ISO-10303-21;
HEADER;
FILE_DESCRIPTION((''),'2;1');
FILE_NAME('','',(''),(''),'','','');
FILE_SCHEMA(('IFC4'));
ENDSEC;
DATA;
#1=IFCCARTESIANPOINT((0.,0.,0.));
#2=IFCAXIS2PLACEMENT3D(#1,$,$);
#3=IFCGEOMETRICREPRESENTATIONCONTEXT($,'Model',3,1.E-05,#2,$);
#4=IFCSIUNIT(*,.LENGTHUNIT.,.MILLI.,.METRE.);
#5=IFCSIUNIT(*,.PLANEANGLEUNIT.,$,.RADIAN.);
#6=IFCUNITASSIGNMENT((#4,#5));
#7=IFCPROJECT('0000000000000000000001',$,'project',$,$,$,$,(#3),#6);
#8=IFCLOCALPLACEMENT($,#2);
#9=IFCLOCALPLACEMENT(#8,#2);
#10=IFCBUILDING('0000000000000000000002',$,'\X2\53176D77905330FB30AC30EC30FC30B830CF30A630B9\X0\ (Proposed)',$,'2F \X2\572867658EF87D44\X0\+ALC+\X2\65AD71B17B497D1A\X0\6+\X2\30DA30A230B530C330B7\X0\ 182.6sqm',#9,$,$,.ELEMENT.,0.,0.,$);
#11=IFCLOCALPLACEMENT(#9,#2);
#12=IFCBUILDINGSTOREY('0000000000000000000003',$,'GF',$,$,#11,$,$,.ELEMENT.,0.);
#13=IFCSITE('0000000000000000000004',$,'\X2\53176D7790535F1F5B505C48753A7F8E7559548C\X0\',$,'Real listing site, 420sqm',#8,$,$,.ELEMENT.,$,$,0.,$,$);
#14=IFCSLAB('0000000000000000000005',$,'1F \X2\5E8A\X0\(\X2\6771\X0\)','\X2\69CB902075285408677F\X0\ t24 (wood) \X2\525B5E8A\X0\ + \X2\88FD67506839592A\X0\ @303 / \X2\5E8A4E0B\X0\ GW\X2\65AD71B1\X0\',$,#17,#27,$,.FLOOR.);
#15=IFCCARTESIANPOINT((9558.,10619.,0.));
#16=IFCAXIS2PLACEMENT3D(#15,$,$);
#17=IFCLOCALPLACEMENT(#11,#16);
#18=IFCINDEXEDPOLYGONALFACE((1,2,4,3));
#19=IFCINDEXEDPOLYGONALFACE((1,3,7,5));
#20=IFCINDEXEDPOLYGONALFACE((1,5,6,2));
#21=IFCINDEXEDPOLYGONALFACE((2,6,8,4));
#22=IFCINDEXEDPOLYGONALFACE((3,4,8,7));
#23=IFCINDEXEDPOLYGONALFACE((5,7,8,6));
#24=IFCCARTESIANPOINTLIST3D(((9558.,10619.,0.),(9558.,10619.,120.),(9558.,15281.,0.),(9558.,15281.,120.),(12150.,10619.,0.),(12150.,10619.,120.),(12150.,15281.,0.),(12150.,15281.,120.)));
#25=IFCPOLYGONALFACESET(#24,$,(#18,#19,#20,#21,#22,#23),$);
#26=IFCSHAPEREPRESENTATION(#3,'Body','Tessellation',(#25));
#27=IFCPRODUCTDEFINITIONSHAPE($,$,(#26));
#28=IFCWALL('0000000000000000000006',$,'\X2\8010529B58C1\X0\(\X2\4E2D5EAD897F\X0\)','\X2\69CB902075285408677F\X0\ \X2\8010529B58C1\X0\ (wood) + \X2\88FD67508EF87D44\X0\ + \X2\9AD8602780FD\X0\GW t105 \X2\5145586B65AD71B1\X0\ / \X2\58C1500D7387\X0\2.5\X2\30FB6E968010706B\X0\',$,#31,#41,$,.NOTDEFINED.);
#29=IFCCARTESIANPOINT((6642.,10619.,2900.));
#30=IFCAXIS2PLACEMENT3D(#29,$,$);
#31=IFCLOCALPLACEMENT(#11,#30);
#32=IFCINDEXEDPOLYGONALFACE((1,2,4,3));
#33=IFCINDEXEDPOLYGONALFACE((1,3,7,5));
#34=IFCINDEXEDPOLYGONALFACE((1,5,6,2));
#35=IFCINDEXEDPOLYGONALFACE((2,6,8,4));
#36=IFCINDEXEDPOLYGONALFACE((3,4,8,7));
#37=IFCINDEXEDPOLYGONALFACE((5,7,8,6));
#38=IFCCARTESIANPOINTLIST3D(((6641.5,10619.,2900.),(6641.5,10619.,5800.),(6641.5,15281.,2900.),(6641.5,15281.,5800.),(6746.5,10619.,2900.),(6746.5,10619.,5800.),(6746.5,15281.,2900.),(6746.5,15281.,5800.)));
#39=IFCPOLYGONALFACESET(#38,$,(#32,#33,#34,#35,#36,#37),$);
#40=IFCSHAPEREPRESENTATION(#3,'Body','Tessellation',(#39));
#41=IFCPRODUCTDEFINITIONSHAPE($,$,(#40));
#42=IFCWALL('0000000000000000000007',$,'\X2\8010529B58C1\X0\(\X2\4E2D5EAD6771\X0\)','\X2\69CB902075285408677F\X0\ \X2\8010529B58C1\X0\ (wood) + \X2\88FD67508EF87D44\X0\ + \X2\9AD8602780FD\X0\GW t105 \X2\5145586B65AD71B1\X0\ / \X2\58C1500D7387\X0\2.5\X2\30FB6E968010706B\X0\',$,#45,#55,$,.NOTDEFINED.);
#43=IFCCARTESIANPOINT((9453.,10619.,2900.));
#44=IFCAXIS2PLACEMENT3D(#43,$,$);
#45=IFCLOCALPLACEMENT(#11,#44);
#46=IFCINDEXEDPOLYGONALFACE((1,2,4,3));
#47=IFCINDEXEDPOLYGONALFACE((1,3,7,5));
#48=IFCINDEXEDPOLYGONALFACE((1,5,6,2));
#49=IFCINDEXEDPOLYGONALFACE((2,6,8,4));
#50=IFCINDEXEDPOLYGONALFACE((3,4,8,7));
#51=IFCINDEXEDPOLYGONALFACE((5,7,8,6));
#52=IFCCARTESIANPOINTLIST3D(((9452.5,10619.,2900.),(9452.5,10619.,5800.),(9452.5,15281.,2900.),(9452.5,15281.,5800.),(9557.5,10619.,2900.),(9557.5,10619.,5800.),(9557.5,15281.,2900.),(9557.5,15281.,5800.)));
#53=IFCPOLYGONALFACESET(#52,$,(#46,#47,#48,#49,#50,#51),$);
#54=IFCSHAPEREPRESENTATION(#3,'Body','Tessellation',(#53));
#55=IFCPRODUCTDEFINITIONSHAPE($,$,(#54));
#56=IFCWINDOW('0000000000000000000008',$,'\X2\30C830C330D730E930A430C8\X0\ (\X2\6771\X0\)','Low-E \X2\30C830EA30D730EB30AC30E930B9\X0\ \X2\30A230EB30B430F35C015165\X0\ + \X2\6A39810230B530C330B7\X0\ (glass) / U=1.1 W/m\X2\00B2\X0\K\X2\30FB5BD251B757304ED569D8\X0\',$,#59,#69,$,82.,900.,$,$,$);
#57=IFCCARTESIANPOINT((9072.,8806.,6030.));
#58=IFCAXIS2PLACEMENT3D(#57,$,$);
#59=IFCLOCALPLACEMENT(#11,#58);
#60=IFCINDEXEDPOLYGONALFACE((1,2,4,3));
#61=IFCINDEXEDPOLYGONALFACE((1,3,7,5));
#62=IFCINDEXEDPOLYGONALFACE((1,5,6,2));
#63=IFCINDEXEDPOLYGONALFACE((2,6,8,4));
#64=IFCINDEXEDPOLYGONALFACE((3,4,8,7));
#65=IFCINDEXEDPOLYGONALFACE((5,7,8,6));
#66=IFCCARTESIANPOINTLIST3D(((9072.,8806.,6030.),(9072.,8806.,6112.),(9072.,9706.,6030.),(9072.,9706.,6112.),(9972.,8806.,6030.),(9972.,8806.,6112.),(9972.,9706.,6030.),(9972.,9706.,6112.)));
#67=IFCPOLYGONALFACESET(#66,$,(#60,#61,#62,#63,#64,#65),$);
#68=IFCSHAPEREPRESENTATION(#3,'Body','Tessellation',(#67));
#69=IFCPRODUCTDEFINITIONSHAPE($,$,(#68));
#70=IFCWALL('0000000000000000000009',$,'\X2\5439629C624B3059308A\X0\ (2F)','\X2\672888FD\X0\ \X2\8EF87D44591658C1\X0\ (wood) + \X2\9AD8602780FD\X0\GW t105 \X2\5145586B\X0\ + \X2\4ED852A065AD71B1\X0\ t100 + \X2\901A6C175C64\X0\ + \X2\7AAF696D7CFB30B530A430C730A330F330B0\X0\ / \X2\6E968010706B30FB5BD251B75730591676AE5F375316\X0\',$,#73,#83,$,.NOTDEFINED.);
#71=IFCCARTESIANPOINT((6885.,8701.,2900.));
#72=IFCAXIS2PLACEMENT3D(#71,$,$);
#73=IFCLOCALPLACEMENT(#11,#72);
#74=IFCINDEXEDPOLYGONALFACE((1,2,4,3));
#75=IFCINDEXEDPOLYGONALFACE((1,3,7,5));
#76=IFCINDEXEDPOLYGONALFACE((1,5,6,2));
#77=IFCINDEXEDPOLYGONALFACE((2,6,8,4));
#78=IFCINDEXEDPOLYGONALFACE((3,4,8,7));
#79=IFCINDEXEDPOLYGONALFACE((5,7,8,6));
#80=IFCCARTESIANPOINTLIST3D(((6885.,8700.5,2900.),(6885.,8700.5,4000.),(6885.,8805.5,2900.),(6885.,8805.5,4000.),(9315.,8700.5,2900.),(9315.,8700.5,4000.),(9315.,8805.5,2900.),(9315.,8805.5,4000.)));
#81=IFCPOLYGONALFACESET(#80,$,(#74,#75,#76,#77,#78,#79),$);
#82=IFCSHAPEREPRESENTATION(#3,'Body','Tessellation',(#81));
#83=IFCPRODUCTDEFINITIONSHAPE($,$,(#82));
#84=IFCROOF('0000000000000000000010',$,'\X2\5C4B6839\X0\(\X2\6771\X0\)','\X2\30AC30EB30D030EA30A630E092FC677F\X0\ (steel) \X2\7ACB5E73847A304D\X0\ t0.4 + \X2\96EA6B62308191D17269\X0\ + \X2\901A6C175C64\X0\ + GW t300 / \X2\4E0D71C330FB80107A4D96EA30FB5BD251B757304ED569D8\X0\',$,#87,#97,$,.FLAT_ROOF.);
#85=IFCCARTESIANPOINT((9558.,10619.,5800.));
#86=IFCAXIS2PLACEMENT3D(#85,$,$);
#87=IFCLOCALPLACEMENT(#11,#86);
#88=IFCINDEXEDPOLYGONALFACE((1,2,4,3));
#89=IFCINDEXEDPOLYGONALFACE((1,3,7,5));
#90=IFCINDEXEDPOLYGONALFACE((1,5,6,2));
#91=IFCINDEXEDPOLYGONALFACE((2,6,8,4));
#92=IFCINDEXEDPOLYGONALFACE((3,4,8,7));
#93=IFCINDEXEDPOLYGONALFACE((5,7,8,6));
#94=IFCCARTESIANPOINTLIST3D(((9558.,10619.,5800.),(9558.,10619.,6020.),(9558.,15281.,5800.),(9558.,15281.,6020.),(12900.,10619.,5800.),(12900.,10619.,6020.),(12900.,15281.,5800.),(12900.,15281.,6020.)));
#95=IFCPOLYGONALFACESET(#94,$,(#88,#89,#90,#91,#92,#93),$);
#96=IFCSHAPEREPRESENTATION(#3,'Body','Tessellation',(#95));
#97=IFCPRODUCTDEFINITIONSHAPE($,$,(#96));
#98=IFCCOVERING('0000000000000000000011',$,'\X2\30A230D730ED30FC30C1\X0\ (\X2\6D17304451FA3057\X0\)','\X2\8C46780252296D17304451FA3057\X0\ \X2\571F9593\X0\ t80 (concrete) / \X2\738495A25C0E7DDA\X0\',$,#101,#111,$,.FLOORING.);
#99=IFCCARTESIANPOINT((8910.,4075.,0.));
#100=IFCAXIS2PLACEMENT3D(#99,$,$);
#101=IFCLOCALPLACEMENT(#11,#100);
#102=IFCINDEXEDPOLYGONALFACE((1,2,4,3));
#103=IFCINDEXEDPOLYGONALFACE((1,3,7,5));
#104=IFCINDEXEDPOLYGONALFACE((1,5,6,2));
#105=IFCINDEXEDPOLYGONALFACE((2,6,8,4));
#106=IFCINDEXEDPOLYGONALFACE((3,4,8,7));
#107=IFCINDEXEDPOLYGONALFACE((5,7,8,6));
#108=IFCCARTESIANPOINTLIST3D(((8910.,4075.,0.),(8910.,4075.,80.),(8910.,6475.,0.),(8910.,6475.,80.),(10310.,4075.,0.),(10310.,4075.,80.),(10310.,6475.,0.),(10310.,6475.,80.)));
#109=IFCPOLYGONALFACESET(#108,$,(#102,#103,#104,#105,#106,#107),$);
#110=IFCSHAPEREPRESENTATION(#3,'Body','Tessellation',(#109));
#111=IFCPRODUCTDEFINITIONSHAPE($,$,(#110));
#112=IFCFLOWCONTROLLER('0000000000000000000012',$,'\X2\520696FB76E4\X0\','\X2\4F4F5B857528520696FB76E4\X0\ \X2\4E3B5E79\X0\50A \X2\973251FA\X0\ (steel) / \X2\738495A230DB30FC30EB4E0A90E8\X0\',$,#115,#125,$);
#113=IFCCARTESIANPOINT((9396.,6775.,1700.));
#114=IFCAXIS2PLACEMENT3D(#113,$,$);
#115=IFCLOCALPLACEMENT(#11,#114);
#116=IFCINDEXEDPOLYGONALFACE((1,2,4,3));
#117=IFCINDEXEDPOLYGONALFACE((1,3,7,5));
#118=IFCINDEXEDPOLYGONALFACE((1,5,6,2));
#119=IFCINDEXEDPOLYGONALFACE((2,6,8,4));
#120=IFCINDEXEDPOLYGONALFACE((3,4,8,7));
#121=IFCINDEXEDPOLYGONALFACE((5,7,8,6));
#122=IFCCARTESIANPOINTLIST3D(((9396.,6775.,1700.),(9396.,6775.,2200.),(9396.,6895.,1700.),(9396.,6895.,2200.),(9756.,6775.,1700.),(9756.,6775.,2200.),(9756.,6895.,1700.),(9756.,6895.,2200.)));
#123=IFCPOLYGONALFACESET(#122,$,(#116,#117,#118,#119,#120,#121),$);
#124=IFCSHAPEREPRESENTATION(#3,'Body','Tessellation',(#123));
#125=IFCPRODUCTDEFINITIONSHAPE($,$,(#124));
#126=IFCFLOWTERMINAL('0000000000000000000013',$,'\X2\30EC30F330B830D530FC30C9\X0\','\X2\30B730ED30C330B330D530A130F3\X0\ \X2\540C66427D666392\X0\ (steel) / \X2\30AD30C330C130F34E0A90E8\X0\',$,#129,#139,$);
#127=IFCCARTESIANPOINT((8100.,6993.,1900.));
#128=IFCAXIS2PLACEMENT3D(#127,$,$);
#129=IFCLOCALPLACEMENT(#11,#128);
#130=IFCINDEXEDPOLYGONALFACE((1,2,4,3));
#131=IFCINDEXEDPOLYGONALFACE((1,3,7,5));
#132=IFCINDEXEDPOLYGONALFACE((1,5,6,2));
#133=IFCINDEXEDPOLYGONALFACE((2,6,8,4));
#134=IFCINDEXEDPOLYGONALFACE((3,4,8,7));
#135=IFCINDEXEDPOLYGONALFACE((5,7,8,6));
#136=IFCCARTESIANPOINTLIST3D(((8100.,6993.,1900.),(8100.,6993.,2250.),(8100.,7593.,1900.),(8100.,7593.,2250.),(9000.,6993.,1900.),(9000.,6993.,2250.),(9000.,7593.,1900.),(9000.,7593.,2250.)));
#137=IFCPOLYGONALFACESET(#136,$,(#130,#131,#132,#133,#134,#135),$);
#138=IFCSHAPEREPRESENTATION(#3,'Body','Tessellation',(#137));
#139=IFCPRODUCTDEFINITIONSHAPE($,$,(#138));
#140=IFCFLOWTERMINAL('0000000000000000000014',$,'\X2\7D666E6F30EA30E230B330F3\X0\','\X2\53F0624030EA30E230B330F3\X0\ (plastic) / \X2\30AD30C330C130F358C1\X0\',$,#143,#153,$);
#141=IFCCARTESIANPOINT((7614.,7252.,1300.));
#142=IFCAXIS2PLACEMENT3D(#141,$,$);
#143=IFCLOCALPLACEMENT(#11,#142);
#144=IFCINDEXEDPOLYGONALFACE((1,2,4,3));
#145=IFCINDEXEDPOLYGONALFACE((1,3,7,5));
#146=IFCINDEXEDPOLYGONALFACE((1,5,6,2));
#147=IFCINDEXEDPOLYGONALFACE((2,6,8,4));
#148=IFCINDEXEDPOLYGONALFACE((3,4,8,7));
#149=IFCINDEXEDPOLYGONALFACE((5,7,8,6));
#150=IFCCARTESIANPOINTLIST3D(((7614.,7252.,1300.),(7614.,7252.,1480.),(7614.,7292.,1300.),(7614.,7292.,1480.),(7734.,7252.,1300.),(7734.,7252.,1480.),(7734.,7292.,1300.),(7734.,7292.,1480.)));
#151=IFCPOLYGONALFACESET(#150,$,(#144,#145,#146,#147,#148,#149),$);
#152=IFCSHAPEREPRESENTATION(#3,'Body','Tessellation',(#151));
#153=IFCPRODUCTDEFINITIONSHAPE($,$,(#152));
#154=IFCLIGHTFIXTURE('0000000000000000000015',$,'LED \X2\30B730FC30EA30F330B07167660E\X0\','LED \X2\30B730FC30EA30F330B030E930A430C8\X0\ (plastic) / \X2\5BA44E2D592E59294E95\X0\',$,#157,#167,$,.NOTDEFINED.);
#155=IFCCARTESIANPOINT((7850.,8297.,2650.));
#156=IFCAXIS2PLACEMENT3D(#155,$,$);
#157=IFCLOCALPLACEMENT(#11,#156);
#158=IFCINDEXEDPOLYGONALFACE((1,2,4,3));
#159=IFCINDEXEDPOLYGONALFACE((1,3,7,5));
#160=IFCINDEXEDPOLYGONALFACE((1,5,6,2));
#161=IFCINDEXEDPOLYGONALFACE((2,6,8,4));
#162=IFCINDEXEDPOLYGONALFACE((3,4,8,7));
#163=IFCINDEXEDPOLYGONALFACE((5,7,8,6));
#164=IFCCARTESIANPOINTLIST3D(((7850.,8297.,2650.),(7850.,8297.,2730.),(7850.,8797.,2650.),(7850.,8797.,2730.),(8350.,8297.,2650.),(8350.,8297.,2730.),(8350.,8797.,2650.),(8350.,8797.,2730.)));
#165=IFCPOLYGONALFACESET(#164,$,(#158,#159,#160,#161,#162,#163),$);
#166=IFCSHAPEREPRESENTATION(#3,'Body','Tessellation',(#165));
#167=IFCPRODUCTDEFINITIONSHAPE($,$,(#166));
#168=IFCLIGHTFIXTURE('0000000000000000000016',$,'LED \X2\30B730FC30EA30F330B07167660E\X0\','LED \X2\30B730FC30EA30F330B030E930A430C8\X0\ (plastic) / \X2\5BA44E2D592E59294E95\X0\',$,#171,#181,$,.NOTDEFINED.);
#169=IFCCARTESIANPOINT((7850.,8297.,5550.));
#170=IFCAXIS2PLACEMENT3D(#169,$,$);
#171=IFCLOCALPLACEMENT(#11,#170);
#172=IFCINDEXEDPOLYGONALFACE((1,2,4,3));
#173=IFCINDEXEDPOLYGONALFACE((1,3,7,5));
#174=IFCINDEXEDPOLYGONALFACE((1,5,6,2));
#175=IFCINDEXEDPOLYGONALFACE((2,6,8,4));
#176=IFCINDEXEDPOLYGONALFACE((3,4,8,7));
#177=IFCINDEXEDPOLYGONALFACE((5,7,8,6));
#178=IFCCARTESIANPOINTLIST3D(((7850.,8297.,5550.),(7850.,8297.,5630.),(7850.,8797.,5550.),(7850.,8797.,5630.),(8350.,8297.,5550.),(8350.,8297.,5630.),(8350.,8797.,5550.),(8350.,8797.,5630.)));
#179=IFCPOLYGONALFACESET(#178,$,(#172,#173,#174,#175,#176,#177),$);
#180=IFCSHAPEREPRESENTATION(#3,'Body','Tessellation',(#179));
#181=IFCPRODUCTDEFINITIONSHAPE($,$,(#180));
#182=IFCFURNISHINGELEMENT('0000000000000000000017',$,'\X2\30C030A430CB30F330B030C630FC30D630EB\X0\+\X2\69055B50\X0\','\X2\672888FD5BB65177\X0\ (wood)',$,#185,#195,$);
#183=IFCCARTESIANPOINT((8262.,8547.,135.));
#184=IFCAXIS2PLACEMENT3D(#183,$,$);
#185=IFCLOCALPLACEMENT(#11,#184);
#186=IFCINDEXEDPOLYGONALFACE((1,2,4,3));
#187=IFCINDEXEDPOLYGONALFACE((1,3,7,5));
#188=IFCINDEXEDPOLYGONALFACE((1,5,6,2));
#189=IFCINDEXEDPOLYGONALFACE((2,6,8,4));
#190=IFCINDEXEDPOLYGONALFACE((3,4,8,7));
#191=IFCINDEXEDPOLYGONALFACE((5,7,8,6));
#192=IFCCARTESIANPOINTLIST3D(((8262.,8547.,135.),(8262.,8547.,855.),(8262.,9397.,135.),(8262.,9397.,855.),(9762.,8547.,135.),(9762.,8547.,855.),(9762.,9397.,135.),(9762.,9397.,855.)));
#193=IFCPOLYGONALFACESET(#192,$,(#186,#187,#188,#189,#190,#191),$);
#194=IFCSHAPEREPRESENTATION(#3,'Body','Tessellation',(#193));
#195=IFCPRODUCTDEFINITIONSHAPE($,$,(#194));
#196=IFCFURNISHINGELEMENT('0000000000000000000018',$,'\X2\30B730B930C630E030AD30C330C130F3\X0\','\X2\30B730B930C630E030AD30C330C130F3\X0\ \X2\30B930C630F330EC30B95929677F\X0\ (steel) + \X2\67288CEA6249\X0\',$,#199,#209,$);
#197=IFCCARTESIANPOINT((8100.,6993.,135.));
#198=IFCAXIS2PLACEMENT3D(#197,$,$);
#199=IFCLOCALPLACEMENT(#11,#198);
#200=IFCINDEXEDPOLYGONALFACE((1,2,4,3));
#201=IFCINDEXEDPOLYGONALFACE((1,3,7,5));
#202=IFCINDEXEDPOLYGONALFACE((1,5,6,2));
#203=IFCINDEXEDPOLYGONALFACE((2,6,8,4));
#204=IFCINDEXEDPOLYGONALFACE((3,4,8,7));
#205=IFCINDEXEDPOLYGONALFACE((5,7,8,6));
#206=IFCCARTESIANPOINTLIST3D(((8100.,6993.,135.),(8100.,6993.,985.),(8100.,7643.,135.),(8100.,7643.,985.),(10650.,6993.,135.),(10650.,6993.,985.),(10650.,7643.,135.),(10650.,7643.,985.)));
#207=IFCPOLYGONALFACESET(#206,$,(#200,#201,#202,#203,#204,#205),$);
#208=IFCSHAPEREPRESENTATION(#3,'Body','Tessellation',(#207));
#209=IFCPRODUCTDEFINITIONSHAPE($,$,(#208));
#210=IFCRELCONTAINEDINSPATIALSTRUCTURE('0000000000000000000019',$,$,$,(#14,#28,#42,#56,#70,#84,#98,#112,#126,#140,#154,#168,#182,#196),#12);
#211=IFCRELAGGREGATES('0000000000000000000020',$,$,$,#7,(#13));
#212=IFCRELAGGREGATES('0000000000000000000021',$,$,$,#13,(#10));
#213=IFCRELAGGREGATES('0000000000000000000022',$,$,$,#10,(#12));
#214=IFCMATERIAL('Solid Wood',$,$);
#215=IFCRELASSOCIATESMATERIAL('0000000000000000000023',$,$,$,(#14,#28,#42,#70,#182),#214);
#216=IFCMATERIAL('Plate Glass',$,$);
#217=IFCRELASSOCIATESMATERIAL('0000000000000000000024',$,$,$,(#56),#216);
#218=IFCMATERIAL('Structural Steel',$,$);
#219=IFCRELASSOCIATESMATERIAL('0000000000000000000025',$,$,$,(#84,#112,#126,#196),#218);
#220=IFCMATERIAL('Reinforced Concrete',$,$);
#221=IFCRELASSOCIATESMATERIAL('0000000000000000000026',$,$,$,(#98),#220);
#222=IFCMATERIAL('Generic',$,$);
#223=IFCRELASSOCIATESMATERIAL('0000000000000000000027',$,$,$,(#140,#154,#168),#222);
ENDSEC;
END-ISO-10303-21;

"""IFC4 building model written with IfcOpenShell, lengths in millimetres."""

from ifc_helpers import new_model, si_unit, frame, frame_2d, origin, place, context, project, spatial, rectangle, extrude, material, element, save


model = new_model("IFC4")

# Units and contexts
model_context = context("Model", 3, precision=1e-05, world=origin())
ifc_project = project(units=[si_unit("LENGTHUNIT", "METRE", prefix="MILLI"), si_unit("PLANEANGLEUNIT", "RADIAN")], contexts=[model_context])

# Site, building, storey
site_placement = place(None, origin())
site = spatial("IfcSite", under=ifc_project, at=site_placement, Name="北海道弟子屈町美留和", ObjectType="Real listing site, 420sqm", CompositionType="ELEMENT", RefElevation=0.0)
building_placement = place(site_placement, origin())
building = spatial("IfcBuilding", under=site, at=building_placement, Name="北海道・ガレージハウス (Proposed)", ObjectType="2F 在来軸組+ALC+断熱等級6+ペアサッシ 182.6sqm", CompositionType="ELEMENT", ElevationOfRefHeight=0.0, ElevationOfTerrain=0.0)
storey_placement = place(building_placement, origin())
storey = spatial("IfcBuildingStorey", under=building, at=storey_placement, Name="GF", CompositionType="ELEMENT", Elevation=0.0)

# Shared definitions
ifc_material_1 = material(Name="Solid Wood")

# Slab
slab_placement = place(storey_placement, frame((9558.0, 10619.0, 0.0)))
element("IfcSlab", 1, at=slab_placement, inside=storey, material=ifc_material_1, Name="1F 床(東)", Description="構造用合板 t24 (wood) 剛床 + 製材根太 @303 / 床下 GW断熱", PredefinedType="FLOOR", context=model_context, shape_type="SweptSolid", body=[
    extrude(rectangle(XDim=2592.0, YDim=4662.0, at=frame_2d((1296.0, 2331.0))), frame((9558.0, 10619.0, 0.0)), (0.0, 0.0, 1.0), 120.0),
])

# Walls
wall_1_placement = place(storey_placement, frame((6642.0, 10619.0, 2900.0)))
element("IfcWall", 2, at=wall_1_placement, inside=storey, material=ifc_material_1, Name="耐力壁(中庭西)", Description="構造用合板 耐力壁 (wood) + 製材軸組 + 高性能GW t105 充填断熱 / 壁倍率2.5・準耐火", PredefinedType="NOTDEFINED", context=model_context, shape_type="SweptSolid", body=[
    extrude(rectangle(XDim=105.0, YDim=4662.0, at=frame_2d((52.0, 2331.0))), frame((6642.0, 10619.0, 2900.0)), (0.0, 0.0, 1.0), 2900.0),
])
wall_2_placement = place(storey_placement, frame((9453.0, 10619.0, 2900.0)))
element("IfcWall", 3, at=wall_2_placement, inside=storey, material=ifc_material_1, Name="耐力壁(中庭東)", Description="構造用合板 耐力壁 (wood) + 製材軸組 + 高性能GW t105 充填断熱 / 壁倍率2.5・準耐火", PredefinedType="NOTDEFINED", context=model_context, shape_type="SweptSolid", body=[
    extrude(rectangle(XDim=105.0, YDim=4662.0, at=frame_2d((52.0, 2331.0))), frame((9453.0, 10619.0, 2900.0)), (0.0, 0.0, 1.0), 2900.0),
])

# Window
ifc_material_2 = material(Name="Plate Glass")
window_placement = place(storey_placement, frame((9072.0, 8806.0, 6030.0)))
element("IfcWindow", 4, at=window_placement, inside=storey, material=ifc_material_2, Name="トップライト (東)", Description="Low-E トリプルガラス アルゴン封入 + 樹脂サッシ (glass) / U=1.1 W/m²K・寒冷地仕様", OverallHeight=82.0, OverallWidth=900.0, context=model_context, shape_type="SweptSolid", body=[
    extrude(rectangle(XDim=900.0, YDim=900.0, at=frame_2d((450.0, 450.0))), frame((9072.0, 8806.0, 6030.0)), (0.0, 0.0, 1.0), 82.0),
])

# Wall
wall_3_placement = place(storey_placement, frame((6885.0, 8701.0, 2900.0)))
element("IfcWall", 5, at=wall_3_placement, inside=storey, material=ifc_material_1, Name="吹抜手すり (2F)", Description="木製 軸組外壁 (wood) + 高性能GW t105 充填 + 付加断熱 t100 + 通気層 + 窯業系サイディング / 準耐火・寒冷地外皮強化", PredefinedType="NOTDEFINED", context=model_context, shape_type="SweptSolid", body=[
    extrude(rectangle(XDim=2430.0, YDim=105.0, at=frame_2d((1215.0, 52.0))), frame((6885.0, 8701.0, 2900.0)), (0.0, 0.0, 1.0), 1100.0),
])

# Roof
ifc_material_3 = material(Name="Structural Steel")
roof_placement = place(storey_placement, frame((9558.0, 10619.0, 5800.0)))
element("IfcRoof", 6, at=roof_placement, inside=storey, material=ifc_material_3, Name="屋根(東)", Description="ガルバリウム鋼板 (steel) 立平葺き t0.4 + 雪止め金物 + 通気層 + GW t300 / 不燃・耐積雪・寒冷地仕様", PredefinedType="FLAT_ROOF", context=model_context, shape_type="SweptSolid", body=[
    extrude(rectangle(XDim=3342.0, YDim=4662.0, at=frame_2d((1671.0, 2331.0))), frame((9558.0, 10619.0, 5800.0)), (0.0, 0.0, 1.0), 220.0),
])

# Covering
ifc_material_4 = material(Name="Reinforced Concrete")
covering_placement = place(storey_placement, frame((8910.0, 4075.0, 0.0)))
element("IfcCovering", 7, at=covering_placement, inside=storey, material=ifc_material_4, Name="アプローチ (洗い出し)", Description="豆砂利洗い出し 土間 t80 (concrete) / 玄関導線", PredefinedType="FLOORING", context=model_context, shape_type="SweptSolid", body=[
    extrude(rectangle(XDim=1400.0, YDim=2400.0, at=frame_2d((700.0, 1200.0))), frame((8910.0, 4075.0, 0.0)), (0.0, 0.0, 1.0), 80.0),
])

# Flow controller
flow_controller_placement = place(storey_placement, frame((9396.0, 6775.0, 1700.0)))
element("IfcFlowController", 8, at=flow_controller_placement, inside=storey, material=ifc_material_3, Name="分電盤", Description="住宅用分電盤 主幹50A 露出 (steel) / 玄関ホール上部", context=model_context, shape_type="SweptSolid", body=[
    extrude(rectangle(XDim=360.0, YDim=120.0, at=frame_2d((180.0, 60.0))), frame((9396.0, 6775.0, 1700.0)), (0.0, 0.0, 1.0), 500.0),
])

# Flow terminals
flow_terminal_1_placement = place(storey_placement, frame((8100.0, 6993.0, 1900.0)))
element("IfcFlowTerminal", 9, at=flow_terminal_1_placement, inside=storey, material=ifc_material_3, Name="レンジフード", Description="シロッコファン 同時給排 (steel) / キッチン上部", context=model_context, shape_type="SweptSolid", body=[
    extrude(rectangle(XDim=900.0, YDim=600.0, at=frame_2d((450.0, 300.0))), frame((8100.0, 6993.0, 1900.0)), (0.0, 0.0, 1.0), 350.0),
])
ifc_material_5 = material(Name="Generic")
flow_terminal_2_placement = place(storey_placement, frame((7614.0, 7252.0, 1300.0)))
element("IfcFlowTerminal", 10, at=flow_terminal_2_placement, inside=storey, material=ifc_material_5, Name="給湯リモコン", Description="台所リモコン (plastic) / キッチン壁", context=model_context, shape_type="SweptSolid", body=[
    extrude(rectangle(XDim=120.0, YDim=40.0, at=frame_2d((60.0, 20.0))), frame((7614.0, 7252.0, 1300.0)), (0.0, 0.0, 1.0), 180.0),
])

# Light fixtures
light_fixture_1_placement = place(storey_placement, frame((7850.0, 8297.0, 2650.0)))
element("IfcLightFixture", 11, at=light_fixture_1_placement, inside=storey, material=ifc_material_5, Name="LED シーリング照明", Description="LED シーリングライト (plastic) / 室中央天井", PredefinedType="NOTDEFINED", context=model_context, shape_type="SweptSolid", body=[
    extrude(rectangle(XDim=500.0, YDim=500.0, at=frame_2d((250.0, 250.0))), frame((7850.0, 8297.0, 2650.0)), (0.0, 0.0, 1.0), 80.0),
])
light_fixture_2_placement = place(storey_placement, frame((7850.0, 8297.0, 5550.0)))
element("IfcLightFixture", 12, at=light_fixture_2_placement, inside=storey, material=ifc_material_5, Name="LED シーリング照明", Description="LED シーリングライト (plastic) / 室中央天井", PredefinedType="NOTDEFINED", context=model_context, shape_type="SweptSolid", body=[
    extrude(rectangle(XDim=500.0, YDim=500.0, at=frame_2d((250.0, 250.0))), frame((7850.0, 8297.0, 5550.0)), (0.0, 0.0, 1.0), 80.0),
])

# Furnishing elements
furnishing_1_placement = place(storey_placement, frame((8262.0, 8547.0, 135.0)))
element("IfcFurnishingElement", 13, at=furnishing_1_placement, inside=storey, material=ifc_material_1, Name="ダイニングテーブル+椅子", Description="木製家具 (wood)", context=model_context, shape_type="SweptSolid", body=[
    extrude(rectangle(XDim=1500.0, YDim=850.0, at=frame_2d((750.0, 425.0))), frame((8262.0, 8547.0, 135.0)), (0.0, 0.0, 1.0), 720.0),
])
furnishing_2_placement = place(storey_placement, frame((8100.0, 6993.0, 135.0)))
element("IfcFurnishingElement", 14, at=furnishing_2_placement, inside=storey, material=ifc_material_3, Name="システムキッチン", Description="システムキッチン ステンレス天板 (steel) + 木質扉", context=model_context, shape_type="SweptSolid", body=[
    extrude(rectangle(XDim=2550.0, YDim=650.0, at=frame_2d((1275.0, 325.0))), frame((8100.0, 6993.0, 135.0)), (0.0, 0.0, 1.0), 850.0),
])

save(model, "model.ifc")
